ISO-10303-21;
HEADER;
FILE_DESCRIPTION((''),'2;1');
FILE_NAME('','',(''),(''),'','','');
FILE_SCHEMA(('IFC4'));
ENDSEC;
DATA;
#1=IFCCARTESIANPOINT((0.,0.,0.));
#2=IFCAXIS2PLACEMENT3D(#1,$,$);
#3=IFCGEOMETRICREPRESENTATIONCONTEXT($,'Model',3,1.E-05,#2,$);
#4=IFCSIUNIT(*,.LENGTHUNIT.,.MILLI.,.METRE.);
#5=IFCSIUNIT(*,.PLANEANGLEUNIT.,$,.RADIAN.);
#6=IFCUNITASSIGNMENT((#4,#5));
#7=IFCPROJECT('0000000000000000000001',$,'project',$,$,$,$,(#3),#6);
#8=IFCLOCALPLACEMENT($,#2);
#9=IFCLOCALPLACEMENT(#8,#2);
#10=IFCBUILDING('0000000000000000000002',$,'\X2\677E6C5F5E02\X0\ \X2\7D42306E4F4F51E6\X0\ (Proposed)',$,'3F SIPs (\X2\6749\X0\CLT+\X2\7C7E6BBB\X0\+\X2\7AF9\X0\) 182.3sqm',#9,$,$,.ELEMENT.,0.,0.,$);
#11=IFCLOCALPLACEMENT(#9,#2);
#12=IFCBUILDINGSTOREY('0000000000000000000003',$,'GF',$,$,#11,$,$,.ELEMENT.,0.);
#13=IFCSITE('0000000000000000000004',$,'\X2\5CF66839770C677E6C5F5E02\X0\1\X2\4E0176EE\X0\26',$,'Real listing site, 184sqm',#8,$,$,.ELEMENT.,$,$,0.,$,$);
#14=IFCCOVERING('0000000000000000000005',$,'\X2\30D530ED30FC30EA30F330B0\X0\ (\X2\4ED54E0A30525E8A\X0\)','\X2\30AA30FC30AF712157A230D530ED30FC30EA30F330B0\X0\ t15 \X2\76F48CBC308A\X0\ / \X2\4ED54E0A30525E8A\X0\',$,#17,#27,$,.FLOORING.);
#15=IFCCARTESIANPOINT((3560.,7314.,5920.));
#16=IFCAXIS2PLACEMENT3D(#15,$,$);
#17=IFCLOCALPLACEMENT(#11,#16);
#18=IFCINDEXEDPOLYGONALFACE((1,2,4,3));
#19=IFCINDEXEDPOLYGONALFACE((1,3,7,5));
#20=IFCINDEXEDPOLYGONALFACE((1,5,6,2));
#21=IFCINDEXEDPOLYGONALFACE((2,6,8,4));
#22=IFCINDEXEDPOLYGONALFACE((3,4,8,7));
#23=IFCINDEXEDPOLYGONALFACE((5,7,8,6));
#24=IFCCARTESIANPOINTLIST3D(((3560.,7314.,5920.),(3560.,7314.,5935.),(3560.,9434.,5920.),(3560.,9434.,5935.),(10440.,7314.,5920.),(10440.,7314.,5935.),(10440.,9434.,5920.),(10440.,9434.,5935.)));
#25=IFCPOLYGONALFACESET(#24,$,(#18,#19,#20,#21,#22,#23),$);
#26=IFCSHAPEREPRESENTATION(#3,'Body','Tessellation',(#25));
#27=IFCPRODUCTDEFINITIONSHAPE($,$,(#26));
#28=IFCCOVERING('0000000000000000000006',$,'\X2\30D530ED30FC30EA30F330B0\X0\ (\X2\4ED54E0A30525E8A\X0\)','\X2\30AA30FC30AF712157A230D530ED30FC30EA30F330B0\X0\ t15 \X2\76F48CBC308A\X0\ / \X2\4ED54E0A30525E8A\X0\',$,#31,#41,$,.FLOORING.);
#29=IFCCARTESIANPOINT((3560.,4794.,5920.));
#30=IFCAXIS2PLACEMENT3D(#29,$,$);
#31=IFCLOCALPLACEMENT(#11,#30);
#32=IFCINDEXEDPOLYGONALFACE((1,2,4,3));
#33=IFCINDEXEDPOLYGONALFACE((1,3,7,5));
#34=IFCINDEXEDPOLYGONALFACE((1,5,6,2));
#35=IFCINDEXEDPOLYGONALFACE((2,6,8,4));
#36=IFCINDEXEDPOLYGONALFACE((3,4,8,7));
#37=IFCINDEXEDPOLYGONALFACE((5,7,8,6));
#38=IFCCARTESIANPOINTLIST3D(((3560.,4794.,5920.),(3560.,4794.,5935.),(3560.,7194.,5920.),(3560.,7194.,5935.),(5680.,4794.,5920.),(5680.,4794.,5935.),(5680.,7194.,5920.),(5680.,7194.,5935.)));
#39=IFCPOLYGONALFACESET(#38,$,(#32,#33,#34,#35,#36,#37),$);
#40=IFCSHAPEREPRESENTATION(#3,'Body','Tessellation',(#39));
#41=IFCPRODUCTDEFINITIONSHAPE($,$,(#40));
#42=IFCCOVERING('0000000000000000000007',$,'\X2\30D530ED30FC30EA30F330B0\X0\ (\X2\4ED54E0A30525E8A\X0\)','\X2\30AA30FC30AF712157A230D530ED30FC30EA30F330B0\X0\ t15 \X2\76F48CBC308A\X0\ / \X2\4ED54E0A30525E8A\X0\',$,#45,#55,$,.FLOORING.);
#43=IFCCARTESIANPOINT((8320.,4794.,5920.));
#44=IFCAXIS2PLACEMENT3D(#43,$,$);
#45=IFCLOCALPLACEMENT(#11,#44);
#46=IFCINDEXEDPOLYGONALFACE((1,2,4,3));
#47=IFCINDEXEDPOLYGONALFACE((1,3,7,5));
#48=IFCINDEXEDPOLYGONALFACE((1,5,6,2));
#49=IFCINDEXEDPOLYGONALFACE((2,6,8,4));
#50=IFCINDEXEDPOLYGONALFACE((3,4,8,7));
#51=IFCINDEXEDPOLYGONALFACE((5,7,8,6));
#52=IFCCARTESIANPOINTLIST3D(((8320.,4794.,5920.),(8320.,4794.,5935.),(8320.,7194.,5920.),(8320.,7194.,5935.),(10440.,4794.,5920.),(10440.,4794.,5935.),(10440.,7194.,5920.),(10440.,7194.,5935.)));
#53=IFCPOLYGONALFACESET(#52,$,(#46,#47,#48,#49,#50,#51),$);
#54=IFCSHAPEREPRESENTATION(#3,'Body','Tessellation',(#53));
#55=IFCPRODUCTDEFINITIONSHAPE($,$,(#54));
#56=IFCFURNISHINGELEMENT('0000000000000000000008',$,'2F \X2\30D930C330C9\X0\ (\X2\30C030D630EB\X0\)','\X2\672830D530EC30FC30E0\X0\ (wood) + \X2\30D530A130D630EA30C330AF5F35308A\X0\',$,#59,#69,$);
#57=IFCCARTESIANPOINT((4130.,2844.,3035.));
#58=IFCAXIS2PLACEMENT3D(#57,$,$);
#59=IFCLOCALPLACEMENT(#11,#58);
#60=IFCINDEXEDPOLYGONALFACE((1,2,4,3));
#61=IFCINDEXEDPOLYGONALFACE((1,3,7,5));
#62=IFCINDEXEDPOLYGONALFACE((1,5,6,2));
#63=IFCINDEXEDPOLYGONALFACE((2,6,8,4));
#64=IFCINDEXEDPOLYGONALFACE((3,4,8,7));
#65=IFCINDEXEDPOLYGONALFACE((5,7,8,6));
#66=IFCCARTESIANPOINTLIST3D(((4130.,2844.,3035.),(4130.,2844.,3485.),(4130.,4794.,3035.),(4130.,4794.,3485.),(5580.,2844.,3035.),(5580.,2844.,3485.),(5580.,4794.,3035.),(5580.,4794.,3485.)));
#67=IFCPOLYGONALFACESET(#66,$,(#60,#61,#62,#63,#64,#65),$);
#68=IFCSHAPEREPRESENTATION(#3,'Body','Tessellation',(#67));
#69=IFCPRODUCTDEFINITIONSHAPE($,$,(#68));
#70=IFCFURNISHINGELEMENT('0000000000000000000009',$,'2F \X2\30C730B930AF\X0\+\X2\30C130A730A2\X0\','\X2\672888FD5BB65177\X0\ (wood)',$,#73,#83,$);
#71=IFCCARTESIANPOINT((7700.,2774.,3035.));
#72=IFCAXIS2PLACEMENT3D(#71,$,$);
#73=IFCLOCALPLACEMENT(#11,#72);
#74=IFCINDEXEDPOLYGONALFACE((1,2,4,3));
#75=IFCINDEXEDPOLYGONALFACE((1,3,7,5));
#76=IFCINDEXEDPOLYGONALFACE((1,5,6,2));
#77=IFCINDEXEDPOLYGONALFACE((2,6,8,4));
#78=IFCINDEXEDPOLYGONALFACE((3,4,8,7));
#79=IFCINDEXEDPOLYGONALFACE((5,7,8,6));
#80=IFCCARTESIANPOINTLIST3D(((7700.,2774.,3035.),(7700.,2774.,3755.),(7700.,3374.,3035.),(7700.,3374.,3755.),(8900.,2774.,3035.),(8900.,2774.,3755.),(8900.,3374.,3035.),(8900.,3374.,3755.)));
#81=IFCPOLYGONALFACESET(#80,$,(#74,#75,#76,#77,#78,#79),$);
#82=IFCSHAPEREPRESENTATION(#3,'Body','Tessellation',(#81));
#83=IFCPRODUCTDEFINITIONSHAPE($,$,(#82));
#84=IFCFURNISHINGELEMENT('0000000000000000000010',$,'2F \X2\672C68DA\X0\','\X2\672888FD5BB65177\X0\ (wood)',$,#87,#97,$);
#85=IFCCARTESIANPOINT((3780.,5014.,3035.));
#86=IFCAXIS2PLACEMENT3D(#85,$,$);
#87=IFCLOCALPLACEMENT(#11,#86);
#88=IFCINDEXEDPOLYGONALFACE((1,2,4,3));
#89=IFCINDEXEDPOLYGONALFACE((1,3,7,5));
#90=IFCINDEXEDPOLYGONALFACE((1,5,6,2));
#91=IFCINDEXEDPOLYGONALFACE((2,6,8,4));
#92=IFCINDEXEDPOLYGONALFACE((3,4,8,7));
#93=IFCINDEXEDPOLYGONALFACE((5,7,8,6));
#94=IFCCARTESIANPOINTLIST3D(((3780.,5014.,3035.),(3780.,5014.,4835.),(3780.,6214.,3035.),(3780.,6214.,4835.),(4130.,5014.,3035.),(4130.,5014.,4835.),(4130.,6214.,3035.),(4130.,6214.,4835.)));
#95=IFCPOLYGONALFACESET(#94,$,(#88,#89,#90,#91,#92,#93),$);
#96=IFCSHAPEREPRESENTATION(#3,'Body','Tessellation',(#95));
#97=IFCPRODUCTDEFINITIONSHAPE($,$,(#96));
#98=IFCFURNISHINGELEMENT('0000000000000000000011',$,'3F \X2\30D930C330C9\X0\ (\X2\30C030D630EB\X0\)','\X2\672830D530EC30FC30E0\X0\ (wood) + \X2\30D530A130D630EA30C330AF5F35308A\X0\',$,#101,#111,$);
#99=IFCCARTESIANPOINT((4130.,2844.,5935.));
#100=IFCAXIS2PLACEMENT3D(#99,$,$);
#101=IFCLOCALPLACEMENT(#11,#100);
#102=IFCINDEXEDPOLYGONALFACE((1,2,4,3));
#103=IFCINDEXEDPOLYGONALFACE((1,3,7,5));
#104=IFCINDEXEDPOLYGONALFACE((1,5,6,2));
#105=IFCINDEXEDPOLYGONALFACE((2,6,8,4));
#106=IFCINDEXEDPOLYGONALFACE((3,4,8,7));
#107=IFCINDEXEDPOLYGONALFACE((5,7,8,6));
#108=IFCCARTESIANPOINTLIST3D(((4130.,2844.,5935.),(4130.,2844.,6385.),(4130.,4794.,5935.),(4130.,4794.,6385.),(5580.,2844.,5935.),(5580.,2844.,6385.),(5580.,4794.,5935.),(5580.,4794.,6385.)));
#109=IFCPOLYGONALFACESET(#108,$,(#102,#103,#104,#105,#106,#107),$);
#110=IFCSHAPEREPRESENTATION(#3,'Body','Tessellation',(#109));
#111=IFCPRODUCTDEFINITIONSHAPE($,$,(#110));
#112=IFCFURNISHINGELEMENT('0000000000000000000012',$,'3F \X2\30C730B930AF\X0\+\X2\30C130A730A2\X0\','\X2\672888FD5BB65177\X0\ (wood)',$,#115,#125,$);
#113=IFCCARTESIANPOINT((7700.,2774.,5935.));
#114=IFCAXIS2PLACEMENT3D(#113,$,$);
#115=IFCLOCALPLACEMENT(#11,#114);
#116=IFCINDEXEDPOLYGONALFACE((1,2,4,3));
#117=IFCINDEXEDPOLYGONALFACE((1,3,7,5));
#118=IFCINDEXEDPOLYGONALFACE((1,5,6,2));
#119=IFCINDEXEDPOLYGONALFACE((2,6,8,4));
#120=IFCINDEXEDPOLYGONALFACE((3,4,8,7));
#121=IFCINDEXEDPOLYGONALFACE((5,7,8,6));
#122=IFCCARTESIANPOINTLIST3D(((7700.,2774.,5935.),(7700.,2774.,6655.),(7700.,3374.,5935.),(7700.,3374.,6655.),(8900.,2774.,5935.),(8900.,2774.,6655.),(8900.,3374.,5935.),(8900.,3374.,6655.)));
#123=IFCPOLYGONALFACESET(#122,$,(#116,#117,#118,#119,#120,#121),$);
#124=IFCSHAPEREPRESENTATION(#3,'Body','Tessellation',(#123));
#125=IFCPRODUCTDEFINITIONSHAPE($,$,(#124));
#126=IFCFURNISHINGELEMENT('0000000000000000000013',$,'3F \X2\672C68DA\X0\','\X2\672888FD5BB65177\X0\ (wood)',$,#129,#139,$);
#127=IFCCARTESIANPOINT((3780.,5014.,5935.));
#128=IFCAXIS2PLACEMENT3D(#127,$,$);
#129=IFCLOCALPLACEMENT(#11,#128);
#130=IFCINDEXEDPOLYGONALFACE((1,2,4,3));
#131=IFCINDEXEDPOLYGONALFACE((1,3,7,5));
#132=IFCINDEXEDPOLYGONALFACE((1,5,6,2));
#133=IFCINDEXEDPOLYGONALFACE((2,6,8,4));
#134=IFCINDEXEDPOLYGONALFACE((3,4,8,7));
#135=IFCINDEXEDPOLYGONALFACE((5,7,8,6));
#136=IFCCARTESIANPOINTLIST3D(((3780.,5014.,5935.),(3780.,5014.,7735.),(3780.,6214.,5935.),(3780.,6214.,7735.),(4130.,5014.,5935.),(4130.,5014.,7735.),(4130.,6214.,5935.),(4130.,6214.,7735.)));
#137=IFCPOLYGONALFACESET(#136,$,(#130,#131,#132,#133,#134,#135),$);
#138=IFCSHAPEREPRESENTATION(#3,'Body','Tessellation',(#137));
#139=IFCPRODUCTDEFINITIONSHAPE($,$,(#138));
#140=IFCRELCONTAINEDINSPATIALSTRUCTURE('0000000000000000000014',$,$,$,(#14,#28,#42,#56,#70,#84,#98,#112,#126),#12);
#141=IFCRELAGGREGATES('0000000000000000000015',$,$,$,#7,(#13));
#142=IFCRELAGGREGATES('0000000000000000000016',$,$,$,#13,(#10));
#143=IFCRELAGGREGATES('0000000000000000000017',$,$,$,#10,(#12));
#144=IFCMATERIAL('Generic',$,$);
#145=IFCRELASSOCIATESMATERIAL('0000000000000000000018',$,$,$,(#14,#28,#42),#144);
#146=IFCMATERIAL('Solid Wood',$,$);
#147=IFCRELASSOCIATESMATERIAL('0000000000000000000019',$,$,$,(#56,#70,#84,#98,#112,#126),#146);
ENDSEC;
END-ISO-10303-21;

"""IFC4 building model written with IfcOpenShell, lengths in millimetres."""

from ifc_helpers import new_model, si_unit, frame, frame_2d, origin, place, context, project, spatial, rectangle, extrude, material, element, save


model = new_model("IFC4")

# Units and contexts
model_context = context("Model", 3, precision=1e-05, world=origin())
ifc_project = project(units=[si_unit("LENGTHUNIT", "METRE", prefix="MILLI"), si_unit("PLANEANGLEUNIT", "RADIAN")], contexts=[model_context])

# Site, building, storey
site_placement = place(None, origin())
site = spatial("IfcSite", under=ifc_project, at=site_placement, Name="島根県松江市1丁目26", ObjectType="Real listing site, 184sqm", CompositionType="ELEMENT", RefElevation=0.0)
building_placement = place(site_placement, origin())
building = spatial("IfcBuilding", under=site, at=building_placement, Name="松江市 終の住処 (Proposed)", ObjectType="3F SIPs (杉CLT+籾殻+竹) 182.3sqm", CompositionType="ELEMENT", ElevationOfRefHeight=0.0, ElevationOfTerrain=0.0)
storey_placement = place(building_placement, origin())
storey = spatial("IfcBuildingStorey", under=building, at=storey_placement, Name="GF", CompositionType="ELEMENT", Elevation=0.0)

# Shared definitions
ifc_material_1 = material(Name="Solid Wood")

# Shared definitions
ifc_material_2 = material(Name="Generic")

# Coverings
covering_1_placement = place(storey_placement, frame((3560.0, 7314.0, 5920.0)))
element("IfcCovering", 1, at=covering_1_placement, inside=storey, material=ifc_material_2, Name="フローリング (仕上げ床)", Description="オーク無垢フローリング t15 直貼り / 仕上げ床", PredefinedType="FLOORING", context=model_context, shape_type="SweptSolid", body=[
    extrude(rectangle(XDim=6880.0, YDim=2120.0, at=frame_2d((3440.0, 1060.0))), frame((3560.0, 7314.0, 5920.0)), (0.0, 0.0, 1.0), 15.0),
])
covering_2_placement = place(storey_placement, frame((3560.0, 4794.0, 5920.0)))
element("IfcCovering", 2, at=covering_2_placement, inside=storey, material=ifc_material_2, Name="フローリング (仕上げ床)", Description="オーク無垢フローリング t15 直貼り / 仕上げ床", PredefinedType="FLOORING", context=model_context, shape_type="SweptSolid", body=[
    extrude(rectangle(XDim=2120.0, YDim=2400.0, at=frame_2d((1060.0, 1200.0))), frame((3560.0, 4794.0, 5920.0)), (0.0, 0.0, 1.0), 15.0),
])
covering_3_placement = place(storey_placement, frame((8320.0, 4794.0, 5920.0)))
element("IfcCovering", 3, at=covering_3_placement, inside=storey, material=ifc_material_2, Name="フローリング (仕上げ床)", Description="オーク無垢フローリング t15 直貼り / 仕上げ床", PredefinedType="FLOORING", context=model_context, shape_type="SweptSolid", body=[
    extrude(rectangle(XDim=2120.0, YDim=2400.0, at=frame_2d((1060.0, 1200.0))), frame((8320.0, 4794.0, 5920.0)), (0.0, 0.0, 1.0), 15.0),
])

# Furnishing elements
furnishing_1_placement = place(storey_placement, frame((4130.0, 2844.0, 3035.0)))
element("IfcFurnishingElement", 4, at=furnishing_1_placement, inside=storey, material=ifc_material_1, Name="2F ベッド (ダブル)", Description="木フレーム (wood) + ファブリック張り", context=model_context, shape_type="SweptSolid", body=[
    extrude(rectangle(XDim=1450.0, YDim=1950.0, at=frame_2d((725.0, 975.0))), frame((4130.0, 2844.0, 3035.0)), (0.0, 0.0, 1.0), 450.0),
])
furnishing_2_placement = place(storey_placement, frame((7700.0, 2774.0, 3035.0)))
element("IfcFurnishingElement", 5, at=furnishing_2_placement, inside=storey, material=ifc_material_1, Name="2F デスク+チェア", Description="木製家具 (wood)", context=model_context, shape_type="SweptSolid", body=[
    extrude(rectangle(XDim=1200.0, YDim=600.0, at=frame_2d((600.0, 300.0))), frame((7700.0, 2774.0, 3035.0)), (0.0, 0.0, 1.0), 720.0),
])
furnishing_3_placement = place(storey_placement, frame((3780.0, 5014.0, 3035.0)))
element("IfcFurnishingElement", 6, at=furnishing_3_placement, inside=storey, material=ifc_material_1, Name="2F 本棚", Description="木製家具 (wood)", context=model_context, shape_type="SweptSolid", body=[
    extrude(rectangle(XDim=350.0, YDim=1200.0, at=frame_2d((175.0, 600.0))), frame((3780.0, 5014.0, 3035.0)), (0.0, 0.0, 1.0), 1800.0),
])
furnishing_4_placement = place(storey_placement, frame((4130.0, 2844.0, 5935.0)))
element("IfcFurnishingElement", 7, at=furnishing_4_placement, inside=storey, material=ifc_material_1, Name="3F ベッド (ダブル)", Description="木フレーム (wood) + ファブリック張り", context=model_context, shape_type="SweptSolid", body=[
    extrude(rectangle(XDim=1450.0, YDim=1950.0, at=frame_2d((725.0, 975.0))), frame((4130.0, 2844.0, 5935.0)), (0.0, 0.0, 1.0), 450.0),
])
furnishing_5_placement = place(storey_placement, frame((7700.0, 2774.0, 5935.0)))
element("IfcFurnishingElement", 8, at=furnishing_5_placement, inside=storey, material=ifc_material_1, Name="3F デスク+チェア", Description="木製家具 (wood)", context=model_context, shape_type="SweptSolid", body=[
    extrude(rectangle(XDim=1200.0, YDim=600.0, at=frame_2d((600.0, 300.0))), frame((7700.0, 2774.0, 5935.0)), (0.0, 0.0, 1.0), 720.0),
])
furnishing_6_placement = place(storey_placement, frame((3780.0, 5014.0, 5935.0)))
element("IfcFurnishingElement", 9, at=furnishing_6_placement, inside=storey, material=ifc_material_1, Name="3F 本棚", Description="木製家具 (wood)", context=model_context, shape_type="SweptSolid", body=[
    extrude(rectangle(XDim=350.0, YDim=1200.0, at=frame_2d((175.0, 600.0))), frame((3780.0, 5014.0, 5935.0)), (0.0, 0.0, 1.0), 1800.0),
])

save(model, "model.ifc")
